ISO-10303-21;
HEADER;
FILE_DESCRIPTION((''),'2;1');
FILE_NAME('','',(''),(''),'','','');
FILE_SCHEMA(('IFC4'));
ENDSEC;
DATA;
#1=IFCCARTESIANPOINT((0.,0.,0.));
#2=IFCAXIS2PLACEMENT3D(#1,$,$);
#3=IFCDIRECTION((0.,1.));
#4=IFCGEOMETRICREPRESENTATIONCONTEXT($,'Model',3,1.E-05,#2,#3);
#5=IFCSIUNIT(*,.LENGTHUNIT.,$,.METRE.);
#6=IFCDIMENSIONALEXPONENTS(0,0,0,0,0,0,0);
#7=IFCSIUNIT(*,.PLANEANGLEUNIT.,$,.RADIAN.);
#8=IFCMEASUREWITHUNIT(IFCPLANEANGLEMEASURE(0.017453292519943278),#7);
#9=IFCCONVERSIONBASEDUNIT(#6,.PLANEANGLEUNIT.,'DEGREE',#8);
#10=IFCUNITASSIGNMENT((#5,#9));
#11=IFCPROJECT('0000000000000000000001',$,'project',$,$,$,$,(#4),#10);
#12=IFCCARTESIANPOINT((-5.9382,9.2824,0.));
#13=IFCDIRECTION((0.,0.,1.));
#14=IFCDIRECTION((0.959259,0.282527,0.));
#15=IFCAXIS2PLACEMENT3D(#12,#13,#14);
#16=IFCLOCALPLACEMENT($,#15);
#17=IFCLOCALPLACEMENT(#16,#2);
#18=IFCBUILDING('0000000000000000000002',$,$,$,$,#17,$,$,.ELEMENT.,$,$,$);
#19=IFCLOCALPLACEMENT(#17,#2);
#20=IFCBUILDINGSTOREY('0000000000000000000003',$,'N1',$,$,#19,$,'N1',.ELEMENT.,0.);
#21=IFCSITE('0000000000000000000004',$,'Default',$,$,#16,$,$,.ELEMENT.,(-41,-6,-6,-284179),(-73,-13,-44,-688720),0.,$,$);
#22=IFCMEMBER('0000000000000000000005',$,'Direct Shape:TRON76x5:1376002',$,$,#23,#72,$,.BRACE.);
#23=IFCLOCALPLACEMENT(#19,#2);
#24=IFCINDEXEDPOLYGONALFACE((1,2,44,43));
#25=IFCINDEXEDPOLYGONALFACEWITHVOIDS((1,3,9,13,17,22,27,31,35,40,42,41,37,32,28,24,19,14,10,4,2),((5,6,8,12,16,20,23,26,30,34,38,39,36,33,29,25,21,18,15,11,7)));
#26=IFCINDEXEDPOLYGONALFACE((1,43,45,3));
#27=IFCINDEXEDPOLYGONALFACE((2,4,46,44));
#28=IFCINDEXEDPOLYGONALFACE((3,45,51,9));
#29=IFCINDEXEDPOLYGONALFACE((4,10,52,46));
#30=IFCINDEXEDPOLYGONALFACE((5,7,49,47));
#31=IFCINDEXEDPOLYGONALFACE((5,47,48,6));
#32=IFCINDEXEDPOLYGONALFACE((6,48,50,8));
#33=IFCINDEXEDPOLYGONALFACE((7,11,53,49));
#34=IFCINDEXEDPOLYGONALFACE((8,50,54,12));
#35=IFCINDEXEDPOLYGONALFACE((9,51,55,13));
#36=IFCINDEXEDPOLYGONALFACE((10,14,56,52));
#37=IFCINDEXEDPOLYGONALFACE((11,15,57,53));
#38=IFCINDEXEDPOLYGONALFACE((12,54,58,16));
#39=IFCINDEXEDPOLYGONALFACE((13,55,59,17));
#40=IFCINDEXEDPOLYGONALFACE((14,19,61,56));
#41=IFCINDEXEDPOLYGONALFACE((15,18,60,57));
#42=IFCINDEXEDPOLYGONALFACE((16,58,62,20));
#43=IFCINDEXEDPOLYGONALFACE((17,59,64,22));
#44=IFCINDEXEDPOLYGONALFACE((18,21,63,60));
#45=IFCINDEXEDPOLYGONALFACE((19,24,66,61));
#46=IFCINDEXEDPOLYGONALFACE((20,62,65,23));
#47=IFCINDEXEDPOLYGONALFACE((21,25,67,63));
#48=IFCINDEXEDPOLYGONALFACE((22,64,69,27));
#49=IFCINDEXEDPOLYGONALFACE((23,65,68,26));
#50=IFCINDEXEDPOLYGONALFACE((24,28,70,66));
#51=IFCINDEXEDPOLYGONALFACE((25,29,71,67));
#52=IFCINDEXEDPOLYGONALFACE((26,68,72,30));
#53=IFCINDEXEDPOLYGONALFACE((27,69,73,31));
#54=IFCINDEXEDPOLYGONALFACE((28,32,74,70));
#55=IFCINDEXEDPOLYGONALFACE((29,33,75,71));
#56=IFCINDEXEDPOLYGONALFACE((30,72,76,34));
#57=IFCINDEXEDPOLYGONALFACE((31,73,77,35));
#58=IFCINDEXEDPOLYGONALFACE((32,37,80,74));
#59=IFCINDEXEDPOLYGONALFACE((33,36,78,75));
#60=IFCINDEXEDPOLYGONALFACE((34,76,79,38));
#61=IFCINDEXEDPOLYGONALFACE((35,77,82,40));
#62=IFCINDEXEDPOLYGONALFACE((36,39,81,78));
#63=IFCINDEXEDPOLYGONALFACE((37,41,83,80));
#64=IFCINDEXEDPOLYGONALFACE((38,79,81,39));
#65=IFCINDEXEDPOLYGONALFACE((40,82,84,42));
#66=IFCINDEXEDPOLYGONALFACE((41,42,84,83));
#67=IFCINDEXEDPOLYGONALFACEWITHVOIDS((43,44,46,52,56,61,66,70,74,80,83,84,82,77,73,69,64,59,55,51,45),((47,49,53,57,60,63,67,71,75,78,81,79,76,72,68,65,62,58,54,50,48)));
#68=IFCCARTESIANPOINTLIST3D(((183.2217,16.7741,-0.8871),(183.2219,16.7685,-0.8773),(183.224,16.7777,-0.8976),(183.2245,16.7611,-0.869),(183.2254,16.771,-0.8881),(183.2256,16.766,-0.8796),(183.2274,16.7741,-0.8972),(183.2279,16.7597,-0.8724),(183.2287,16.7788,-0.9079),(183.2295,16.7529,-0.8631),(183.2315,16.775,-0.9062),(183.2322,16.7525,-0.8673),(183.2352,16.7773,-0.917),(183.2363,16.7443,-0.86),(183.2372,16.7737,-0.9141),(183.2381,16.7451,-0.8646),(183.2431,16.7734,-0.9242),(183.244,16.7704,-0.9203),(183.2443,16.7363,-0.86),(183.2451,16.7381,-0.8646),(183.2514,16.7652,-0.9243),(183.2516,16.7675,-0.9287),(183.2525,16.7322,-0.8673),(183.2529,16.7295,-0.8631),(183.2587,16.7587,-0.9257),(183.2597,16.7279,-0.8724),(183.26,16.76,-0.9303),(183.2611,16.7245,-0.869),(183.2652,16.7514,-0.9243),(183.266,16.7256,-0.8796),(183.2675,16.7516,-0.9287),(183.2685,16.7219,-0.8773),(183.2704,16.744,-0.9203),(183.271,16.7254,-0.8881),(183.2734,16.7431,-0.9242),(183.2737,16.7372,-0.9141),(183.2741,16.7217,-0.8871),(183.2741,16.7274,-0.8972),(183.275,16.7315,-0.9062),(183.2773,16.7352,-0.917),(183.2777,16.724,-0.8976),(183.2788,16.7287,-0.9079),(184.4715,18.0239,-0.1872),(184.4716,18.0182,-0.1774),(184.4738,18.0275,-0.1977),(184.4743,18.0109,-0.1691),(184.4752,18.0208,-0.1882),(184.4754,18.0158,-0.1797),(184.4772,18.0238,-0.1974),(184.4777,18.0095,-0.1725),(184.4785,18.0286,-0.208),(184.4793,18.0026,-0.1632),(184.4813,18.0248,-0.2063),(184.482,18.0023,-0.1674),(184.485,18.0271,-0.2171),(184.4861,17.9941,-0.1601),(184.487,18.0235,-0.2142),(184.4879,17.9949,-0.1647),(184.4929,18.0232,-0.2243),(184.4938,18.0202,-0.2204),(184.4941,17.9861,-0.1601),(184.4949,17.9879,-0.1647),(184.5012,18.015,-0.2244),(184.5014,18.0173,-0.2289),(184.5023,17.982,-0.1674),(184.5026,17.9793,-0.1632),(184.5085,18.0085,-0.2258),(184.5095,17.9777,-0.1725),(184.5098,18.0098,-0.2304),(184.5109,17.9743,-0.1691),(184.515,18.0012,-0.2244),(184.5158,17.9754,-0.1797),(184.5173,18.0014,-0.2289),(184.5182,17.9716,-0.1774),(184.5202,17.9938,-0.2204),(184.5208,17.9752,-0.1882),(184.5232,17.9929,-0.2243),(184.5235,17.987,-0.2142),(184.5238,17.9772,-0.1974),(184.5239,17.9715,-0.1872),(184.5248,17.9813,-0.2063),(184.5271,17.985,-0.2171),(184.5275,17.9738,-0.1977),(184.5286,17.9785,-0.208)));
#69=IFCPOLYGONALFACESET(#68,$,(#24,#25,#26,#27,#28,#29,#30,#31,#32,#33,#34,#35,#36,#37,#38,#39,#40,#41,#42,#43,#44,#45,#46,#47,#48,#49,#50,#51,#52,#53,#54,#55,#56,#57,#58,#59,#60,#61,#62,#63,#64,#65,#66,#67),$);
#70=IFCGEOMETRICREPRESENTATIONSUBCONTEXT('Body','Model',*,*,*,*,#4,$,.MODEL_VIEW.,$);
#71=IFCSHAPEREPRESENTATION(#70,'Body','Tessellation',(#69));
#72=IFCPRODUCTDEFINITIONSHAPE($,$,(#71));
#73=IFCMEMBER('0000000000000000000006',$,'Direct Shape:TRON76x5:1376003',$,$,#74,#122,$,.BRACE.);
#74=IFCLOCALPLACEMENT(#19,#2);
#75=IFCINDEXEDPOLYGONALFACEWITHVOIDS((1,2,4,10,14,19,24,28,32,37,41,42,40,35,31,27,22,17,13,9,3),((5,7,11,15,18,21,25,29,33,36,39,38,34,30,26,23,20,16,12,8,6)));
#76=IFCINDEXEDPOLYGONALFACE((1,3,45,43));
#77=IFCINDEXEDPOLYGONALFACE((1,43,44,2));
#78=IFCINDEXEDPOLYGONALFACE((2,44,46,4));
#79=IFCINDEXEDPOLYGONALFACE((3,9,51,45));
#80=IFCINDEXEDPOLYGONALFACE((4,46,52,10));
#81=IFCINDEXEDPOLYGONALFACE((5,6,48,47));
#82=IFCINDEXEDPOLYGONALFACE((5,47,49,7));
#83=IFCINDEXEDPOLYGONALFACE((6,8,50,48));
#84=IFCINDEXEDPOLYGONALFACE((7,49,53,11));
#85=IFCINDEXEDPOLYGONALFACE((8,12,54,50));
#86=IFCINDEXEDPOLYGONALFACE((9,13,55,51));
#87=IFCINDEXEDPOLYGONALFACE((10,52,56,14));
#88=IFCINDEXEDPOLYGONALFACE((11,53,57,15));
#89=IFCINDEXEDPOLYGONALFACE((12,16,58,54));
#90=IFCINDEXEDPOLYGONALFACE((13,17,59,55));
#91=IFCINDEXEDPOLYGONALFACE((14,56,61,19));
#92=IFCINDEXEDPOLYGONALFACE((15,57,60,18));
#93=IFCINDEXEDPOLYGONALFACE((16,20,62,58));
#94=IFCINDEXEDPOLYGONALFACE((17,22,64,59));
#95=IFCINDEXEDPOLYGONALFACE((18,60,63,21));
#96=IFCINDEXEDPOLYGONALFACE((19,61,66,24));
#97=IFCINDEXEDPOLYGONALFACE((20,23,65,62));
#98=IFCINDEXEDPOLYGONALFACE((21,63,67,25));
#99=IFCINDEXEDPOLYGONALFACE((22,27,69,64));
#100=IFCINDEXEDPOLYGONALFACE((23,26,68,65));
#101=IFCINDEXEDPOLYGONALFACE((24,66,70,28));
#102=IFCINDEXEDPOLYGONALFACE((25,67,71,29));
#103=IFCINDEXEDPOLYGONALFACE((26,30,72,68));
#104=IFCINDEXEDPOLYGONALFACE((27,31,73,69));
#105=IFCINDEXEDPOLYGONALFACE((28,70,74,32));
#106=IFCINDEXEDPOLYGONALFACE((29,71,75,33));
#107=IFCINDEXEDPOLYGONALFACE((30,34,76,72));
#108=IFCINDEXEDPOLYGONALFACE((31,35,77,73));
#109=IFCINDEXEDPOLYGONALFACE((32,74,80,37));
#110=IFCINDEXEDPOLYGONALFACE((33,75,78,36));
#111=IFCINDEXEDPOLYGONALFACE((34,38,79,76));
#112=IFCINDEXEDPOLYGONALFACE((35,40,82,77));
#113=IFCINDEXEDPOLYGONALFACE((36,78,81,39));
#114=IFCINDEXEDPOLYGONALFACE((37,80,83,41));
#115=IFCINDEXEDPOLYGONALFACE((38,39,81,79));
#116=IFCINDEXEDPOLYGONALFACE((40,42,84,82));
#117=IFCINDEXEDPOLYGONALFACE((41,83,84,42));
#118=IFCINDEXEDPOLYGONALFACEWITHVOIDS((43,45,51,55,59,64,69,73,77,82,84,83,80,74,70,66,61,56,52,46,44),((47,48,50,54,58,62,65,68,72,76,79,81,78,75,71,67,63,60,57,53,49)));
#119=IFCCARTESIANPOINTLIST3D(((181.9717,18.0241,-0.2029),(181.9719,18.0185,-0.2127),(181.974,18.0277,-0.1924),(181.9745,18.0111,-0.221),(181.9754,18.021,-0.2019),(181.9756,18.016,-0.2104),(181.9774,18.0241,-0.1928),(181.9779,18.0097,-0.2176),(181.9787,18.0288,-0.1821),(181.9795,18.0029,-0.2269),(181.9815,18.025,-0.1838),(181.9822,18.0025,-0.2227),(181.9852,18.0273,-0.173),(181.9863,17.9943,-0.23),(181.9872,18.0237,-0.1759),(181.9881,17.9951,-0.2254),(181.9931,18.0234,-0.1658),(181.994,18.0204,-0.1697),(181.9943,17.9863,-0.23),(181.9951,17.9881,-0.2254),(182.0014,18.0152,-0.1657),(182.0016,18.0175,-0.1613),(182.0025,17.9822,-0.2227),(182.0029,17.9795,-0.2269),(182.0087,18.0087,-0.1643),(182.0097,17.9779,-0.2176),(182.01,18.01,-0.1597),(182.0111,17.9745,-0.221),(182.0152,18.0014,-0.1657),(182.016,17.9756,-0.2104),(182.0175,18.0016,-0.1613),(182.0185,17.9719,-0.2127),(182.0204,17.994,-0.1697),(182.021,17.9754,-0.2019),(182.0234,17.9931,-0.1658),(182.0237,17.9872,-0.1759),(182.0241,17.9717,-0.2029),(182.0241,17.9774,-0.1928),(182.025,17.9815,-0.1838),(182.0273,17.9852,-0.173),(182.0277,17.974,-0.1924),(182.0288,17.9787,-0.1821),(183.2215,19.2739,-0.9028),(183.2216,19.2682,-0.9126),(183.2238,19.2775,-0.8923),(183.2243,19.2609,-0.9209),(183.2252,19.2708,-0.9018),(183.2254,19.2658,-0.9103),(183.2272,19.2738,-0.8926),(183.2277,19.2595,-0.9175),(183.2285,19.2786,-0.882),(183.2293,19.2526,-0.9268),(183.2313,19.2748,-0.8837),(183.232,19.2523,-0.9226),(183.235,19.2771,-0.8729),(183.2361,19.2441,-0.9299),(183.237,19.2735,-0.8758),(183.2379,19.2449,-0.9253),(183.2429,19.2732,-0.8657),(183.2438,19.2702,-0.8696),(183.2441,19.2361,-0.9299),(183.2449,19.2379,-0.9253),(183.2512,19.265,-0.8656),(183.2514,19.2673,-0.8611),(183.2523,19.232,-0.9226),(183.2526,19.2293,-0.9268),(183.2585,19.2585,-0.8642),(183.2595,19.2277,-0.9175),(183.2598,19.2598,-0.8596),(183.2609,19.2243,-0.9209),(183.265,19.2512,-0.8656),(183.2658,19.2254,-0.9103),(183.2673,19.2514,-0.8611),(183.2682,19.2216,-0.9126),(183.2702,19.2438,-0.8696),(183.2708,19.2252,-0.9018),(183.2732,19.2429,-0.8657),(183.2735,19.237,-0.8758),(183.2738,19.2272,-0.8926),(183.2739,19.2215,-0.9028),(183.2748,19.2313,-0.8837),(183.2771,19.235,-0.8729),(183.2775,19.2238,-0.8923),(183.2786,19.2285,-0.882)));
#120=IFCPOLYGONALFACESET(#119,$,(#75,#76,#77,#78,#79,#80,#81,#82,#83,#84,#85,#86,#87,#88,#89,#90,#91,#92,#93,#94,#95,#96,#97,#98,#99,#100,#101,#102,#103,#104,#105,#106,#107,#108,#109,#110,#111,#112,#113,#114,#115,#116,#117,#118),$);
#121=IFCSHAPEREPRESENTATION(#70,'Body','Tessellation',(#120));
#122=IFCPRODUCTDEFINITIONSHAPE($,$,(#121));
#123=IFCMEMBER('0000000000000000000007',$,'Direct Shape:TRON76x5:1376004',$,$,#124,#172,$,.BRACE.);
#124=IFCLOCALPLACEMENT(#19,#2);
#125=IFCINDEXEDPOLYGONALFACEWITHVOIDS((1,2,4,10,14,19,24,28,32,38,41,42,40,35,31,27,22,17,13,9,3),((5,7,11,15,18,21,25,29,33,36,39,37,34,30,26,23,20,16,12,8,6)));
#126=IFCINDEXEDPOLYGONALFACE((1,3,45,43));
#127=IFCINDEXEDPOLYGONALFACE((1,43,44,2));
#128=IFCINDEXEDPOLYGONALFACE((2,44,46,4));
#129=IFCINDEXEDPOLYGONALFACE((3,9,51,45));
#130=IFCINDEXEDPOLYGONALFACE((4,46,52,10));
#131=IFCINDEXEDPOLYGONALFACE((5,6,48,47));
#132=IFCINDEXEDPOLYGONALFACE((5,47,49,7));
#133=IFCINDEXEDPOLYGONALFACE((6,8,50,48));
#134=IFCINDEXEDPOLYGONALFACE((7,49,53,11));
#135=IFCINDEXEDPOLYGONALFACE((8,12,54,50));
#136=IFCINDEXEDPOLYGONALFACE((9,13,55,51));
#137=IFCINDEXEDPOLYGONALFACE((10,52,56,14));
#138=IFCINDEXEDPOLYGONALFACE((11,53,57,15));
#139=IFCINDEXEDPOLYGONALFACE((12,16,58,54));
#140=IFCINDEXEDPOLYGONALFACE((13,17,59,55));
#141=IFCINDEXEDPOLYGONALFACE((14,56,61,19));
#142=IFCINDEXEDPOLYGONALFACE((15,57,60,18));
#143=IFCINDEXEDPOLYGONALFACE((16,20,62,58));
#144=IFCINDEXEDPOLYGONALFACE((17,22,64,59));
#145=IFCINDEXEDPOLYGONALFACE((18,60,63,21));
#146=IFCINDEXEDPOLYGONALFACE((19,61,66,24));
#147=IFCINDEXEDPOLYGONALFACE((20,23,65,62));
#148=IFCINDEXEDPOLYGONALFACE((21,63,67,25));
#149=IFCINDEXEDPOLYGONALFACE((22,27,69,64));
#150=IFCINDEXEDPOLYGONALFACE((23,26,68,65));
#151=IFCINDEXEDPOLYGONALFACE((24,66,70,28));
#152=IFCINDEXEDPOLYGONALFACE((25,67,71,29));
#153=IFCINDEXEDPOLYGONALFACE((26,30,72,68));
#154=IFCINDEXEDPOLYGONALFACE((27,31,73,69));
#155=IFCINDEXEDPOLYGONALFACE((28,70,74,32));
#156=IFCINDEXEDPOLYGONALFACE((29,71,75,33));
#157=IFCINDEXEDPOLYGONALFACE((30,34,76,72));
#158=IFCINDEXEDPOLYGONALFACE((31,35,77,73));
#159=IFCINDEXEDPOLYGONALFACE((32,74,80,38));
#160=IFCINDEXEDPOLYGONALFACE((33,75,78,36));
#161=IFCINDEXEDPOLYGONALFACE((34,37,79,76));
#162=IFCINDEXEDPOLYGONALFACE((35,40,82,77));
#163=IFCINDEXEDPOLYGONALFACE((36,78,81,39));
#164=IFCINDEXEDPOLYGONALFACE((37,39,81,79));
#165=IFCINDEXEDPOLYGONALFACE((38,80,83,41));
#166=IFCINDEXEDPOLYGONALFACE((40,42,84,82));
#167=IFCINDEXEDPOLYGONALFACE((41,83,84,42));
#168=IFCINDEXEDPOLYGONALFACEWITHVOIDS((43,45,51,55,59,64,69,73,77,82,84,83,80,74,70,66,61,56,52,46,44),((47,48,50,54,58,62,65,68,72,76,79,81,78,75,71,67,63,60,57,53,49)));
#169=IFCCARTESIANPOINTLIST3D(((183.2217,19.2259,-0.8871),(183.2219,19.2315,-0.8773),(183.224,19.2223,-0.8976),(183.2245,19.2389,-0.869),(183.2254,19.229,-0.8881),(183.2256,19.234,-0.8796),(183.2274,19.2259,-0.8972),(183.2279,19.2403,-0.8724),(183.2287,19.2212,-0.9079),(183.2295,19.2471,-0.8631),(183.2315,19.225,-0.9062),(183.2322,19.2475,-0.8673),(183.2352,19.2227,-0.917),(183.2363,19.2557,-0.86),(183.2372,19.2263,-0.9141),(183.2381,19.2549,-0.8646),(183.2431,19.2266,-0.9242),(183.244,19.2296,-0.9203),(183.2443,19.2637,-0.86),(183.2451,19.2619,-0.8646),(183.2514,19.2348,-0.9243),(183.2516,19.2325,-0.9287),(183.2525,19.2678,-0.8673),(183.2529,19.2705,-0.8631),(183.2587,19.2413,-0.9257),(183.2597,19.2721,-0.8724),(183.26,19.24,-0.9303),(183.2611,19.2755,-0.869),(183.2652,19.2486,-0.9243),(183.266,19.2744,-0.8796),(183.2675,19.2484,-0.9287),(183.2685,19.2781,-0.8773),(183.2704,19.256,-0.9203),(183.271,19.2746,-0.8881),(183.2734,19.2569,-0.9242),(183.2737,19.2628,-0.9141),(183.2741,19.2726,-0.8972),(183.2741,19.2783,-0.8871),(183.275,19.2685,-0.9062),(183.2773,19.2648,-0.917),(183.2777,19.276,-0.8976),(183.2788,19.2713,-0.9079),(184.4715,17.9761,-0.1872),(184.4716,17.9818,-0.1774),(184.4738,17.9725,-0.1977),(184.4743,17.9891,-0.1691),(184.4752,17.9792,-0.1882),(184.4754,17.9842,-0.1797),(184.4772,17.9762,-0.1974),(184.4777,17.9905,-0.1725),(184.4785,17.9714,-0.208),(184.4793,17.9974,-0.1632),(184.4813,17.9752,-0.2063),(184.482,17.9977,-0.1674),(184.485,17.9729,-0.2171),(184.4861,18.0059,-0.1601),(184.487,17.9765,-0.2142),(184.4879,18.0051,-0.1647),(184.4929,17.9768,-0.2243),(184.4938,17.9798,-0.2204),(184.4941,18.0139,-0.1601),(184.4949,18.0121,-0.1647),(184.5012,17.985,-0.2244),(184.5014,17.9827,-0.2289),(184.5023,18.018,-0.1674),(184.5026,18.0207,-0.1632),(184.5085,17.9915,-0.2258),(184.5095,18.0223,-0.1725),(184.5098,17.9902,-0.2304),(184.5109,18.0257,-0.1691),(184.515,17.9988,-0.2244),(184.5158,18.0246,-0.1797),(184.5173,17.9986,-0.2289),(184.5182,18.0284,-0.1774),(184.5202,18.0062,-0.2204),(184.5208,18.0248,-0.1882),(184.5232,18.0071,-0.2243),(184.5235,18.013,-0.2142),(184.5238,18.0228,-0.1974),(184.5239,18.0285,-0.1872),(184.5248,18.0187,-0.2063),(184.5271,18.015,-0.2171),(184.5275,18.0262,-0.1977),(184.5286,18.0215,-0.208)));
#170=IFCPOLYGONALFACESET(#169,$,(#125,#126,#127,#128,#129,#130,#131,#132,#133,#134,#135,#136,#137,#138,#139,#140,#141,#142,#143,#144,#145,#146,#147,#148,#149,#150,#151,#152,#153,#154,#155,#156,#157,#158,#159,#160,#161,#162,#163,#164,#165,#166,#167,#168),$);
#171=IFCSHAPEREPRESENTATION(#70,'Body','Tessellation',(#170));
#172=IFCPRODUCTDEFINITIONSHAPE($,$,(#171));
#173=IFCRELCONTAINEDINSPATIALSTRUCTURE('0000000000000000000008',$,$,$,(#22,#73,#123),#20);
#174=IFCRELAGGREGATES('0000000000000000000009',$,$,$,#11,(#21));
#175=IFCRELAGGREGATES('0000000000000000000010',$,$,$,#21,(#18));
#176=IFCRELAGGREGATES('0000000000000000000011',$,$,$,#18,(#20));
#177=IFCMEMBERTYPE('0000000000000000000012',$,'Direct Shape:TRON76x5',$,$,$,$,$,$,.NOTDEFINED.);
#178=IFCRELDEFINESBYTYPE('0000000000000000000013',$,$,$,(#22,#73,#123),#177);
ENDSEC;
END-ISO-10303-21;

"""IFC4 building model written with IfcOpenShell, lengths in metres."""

from ifc_helpers import new_model, entity, si_unit, converted_unit, direction, frame, frame_2d, origin, origin_2d_with_axis, place, context, subcontext, project, spatial, hollow_circle, extrude, type_object, element, save


model = new_model("IFC4")

# Units and contexts
model_context = context("Model", 3, precision=1e-05, world=origin(), true_north=direction((0.0, 1.0)))
body_context = subcontext(model_context, "Body", "Model", "MODEL_VIEW")
ifc_project = project(units=[si_unit("LENGTHUNIT", "METRE"), converted_unit("PLANEANGLEUNIT", "DEGREE", entity("IfcPlaneAngleMeasure", 0.017453292519943278), si_unit("PLANEANGLEUNIT", "RADIAN"), dimensions=[0, 0, 0, 0, 0, 0, 0])], contexts=[model_context])

# Site, building, storey
site_placement = place(None, frame((-5.9382, 9.2824, 0.0), z_axis=(0.0, 0.0, 1.0), x_axis=(0.959259, 0.282527, 0.0)))
site = spatial("IfcSite", under=ifc_project, at=site_placement, Name="Default", CompositionType="ELEMENT", RefLatitude=(-41, -6, -6, -284179), RefLongitude=(-73, -13, -44, -688720), RefElevation=0.0)
building_placement = place(site_placement, origin())
building = spatial("IfcBuilding", under=site, at=building_placement, CompositionType="ELEMENT")
storey_placement = place(building_placement, origin())
storey = spatial("IfcBuildingStorey", under=building, at=storey_placement, Name="N1", LongName="N1", CompositionType="ELEMENT", Elevation=0.0)

# Members
member_type_1 = type_object("IfcMemberType", Name="Direct Shape:TRON76x5", PredefinedType="NOTDEFINED")
member_1_placement = place(storey_placement, origin())
element("IfcMember", 1, at=member_1_placement, inside=storey, type_object=member_type_1, Name="Direct Shape:TRON76x5:1376002", PredefinedType="BRACE", context=body_context, shape_type="SweptSolid", body=[
    extrude(hollow_circle(Radius=0.0381, WallThickness=0.005, at=origin_2d_with_axis()), frame((183.2501, 16.7501, -0.8949), z_axis=(0.65744, 0.65744, 0.368166), x_axis=(0.260333, 0.260333, -0.92976)), (0.0, 0.0, 1.0), 1.901),
])
member_2_placement = place(storey_placement, origin())
element("IfcMember", 2, at=member_2_placement, inside=storey, type_object=member_type_1, Name="Direct Shape:TRON76x5:1376003", PredefinedType="BRACE", context=body_context, shape_type="SweptSolid", body=[
    extrude(hollow_circle(Radius=0.0381, WallThickness=0.005, at=frame_2d((0.0, 0.0), x_axis=(1.0, 0.0))), frame((182.0001, 18.0001, -0.1951), z_axis=(0.65744, 0.65744, -0.368166), x_axis=(0.260333, 0.260333, 0.92976)), (0.0, 0.0, 1.0), 1.901),
])
member_3_placement = place(storey_placement, origin())
element("IfcMember", 3, at=member_3_placement, inside=storey, type_object=member_type_1, Name="Direct Shape:TRON76x5:1376004", PredefinedType="BRACE", context=body_context, shape_type="SweptSolid", body=[
    extrude(hollow_circle(Radius=0.0381, WallThickness=0.005, at=origin_2d_with_axis()), frame((183.2501, 19.2499, -0.8949), z_axis=(0.65744, -0.65744, 0.368166), x_axis=(0.260333, -0.260333, -0.92976)), (0.0, 0.0, 1.0), 1.901),
])

save(model, "model.ifc")
